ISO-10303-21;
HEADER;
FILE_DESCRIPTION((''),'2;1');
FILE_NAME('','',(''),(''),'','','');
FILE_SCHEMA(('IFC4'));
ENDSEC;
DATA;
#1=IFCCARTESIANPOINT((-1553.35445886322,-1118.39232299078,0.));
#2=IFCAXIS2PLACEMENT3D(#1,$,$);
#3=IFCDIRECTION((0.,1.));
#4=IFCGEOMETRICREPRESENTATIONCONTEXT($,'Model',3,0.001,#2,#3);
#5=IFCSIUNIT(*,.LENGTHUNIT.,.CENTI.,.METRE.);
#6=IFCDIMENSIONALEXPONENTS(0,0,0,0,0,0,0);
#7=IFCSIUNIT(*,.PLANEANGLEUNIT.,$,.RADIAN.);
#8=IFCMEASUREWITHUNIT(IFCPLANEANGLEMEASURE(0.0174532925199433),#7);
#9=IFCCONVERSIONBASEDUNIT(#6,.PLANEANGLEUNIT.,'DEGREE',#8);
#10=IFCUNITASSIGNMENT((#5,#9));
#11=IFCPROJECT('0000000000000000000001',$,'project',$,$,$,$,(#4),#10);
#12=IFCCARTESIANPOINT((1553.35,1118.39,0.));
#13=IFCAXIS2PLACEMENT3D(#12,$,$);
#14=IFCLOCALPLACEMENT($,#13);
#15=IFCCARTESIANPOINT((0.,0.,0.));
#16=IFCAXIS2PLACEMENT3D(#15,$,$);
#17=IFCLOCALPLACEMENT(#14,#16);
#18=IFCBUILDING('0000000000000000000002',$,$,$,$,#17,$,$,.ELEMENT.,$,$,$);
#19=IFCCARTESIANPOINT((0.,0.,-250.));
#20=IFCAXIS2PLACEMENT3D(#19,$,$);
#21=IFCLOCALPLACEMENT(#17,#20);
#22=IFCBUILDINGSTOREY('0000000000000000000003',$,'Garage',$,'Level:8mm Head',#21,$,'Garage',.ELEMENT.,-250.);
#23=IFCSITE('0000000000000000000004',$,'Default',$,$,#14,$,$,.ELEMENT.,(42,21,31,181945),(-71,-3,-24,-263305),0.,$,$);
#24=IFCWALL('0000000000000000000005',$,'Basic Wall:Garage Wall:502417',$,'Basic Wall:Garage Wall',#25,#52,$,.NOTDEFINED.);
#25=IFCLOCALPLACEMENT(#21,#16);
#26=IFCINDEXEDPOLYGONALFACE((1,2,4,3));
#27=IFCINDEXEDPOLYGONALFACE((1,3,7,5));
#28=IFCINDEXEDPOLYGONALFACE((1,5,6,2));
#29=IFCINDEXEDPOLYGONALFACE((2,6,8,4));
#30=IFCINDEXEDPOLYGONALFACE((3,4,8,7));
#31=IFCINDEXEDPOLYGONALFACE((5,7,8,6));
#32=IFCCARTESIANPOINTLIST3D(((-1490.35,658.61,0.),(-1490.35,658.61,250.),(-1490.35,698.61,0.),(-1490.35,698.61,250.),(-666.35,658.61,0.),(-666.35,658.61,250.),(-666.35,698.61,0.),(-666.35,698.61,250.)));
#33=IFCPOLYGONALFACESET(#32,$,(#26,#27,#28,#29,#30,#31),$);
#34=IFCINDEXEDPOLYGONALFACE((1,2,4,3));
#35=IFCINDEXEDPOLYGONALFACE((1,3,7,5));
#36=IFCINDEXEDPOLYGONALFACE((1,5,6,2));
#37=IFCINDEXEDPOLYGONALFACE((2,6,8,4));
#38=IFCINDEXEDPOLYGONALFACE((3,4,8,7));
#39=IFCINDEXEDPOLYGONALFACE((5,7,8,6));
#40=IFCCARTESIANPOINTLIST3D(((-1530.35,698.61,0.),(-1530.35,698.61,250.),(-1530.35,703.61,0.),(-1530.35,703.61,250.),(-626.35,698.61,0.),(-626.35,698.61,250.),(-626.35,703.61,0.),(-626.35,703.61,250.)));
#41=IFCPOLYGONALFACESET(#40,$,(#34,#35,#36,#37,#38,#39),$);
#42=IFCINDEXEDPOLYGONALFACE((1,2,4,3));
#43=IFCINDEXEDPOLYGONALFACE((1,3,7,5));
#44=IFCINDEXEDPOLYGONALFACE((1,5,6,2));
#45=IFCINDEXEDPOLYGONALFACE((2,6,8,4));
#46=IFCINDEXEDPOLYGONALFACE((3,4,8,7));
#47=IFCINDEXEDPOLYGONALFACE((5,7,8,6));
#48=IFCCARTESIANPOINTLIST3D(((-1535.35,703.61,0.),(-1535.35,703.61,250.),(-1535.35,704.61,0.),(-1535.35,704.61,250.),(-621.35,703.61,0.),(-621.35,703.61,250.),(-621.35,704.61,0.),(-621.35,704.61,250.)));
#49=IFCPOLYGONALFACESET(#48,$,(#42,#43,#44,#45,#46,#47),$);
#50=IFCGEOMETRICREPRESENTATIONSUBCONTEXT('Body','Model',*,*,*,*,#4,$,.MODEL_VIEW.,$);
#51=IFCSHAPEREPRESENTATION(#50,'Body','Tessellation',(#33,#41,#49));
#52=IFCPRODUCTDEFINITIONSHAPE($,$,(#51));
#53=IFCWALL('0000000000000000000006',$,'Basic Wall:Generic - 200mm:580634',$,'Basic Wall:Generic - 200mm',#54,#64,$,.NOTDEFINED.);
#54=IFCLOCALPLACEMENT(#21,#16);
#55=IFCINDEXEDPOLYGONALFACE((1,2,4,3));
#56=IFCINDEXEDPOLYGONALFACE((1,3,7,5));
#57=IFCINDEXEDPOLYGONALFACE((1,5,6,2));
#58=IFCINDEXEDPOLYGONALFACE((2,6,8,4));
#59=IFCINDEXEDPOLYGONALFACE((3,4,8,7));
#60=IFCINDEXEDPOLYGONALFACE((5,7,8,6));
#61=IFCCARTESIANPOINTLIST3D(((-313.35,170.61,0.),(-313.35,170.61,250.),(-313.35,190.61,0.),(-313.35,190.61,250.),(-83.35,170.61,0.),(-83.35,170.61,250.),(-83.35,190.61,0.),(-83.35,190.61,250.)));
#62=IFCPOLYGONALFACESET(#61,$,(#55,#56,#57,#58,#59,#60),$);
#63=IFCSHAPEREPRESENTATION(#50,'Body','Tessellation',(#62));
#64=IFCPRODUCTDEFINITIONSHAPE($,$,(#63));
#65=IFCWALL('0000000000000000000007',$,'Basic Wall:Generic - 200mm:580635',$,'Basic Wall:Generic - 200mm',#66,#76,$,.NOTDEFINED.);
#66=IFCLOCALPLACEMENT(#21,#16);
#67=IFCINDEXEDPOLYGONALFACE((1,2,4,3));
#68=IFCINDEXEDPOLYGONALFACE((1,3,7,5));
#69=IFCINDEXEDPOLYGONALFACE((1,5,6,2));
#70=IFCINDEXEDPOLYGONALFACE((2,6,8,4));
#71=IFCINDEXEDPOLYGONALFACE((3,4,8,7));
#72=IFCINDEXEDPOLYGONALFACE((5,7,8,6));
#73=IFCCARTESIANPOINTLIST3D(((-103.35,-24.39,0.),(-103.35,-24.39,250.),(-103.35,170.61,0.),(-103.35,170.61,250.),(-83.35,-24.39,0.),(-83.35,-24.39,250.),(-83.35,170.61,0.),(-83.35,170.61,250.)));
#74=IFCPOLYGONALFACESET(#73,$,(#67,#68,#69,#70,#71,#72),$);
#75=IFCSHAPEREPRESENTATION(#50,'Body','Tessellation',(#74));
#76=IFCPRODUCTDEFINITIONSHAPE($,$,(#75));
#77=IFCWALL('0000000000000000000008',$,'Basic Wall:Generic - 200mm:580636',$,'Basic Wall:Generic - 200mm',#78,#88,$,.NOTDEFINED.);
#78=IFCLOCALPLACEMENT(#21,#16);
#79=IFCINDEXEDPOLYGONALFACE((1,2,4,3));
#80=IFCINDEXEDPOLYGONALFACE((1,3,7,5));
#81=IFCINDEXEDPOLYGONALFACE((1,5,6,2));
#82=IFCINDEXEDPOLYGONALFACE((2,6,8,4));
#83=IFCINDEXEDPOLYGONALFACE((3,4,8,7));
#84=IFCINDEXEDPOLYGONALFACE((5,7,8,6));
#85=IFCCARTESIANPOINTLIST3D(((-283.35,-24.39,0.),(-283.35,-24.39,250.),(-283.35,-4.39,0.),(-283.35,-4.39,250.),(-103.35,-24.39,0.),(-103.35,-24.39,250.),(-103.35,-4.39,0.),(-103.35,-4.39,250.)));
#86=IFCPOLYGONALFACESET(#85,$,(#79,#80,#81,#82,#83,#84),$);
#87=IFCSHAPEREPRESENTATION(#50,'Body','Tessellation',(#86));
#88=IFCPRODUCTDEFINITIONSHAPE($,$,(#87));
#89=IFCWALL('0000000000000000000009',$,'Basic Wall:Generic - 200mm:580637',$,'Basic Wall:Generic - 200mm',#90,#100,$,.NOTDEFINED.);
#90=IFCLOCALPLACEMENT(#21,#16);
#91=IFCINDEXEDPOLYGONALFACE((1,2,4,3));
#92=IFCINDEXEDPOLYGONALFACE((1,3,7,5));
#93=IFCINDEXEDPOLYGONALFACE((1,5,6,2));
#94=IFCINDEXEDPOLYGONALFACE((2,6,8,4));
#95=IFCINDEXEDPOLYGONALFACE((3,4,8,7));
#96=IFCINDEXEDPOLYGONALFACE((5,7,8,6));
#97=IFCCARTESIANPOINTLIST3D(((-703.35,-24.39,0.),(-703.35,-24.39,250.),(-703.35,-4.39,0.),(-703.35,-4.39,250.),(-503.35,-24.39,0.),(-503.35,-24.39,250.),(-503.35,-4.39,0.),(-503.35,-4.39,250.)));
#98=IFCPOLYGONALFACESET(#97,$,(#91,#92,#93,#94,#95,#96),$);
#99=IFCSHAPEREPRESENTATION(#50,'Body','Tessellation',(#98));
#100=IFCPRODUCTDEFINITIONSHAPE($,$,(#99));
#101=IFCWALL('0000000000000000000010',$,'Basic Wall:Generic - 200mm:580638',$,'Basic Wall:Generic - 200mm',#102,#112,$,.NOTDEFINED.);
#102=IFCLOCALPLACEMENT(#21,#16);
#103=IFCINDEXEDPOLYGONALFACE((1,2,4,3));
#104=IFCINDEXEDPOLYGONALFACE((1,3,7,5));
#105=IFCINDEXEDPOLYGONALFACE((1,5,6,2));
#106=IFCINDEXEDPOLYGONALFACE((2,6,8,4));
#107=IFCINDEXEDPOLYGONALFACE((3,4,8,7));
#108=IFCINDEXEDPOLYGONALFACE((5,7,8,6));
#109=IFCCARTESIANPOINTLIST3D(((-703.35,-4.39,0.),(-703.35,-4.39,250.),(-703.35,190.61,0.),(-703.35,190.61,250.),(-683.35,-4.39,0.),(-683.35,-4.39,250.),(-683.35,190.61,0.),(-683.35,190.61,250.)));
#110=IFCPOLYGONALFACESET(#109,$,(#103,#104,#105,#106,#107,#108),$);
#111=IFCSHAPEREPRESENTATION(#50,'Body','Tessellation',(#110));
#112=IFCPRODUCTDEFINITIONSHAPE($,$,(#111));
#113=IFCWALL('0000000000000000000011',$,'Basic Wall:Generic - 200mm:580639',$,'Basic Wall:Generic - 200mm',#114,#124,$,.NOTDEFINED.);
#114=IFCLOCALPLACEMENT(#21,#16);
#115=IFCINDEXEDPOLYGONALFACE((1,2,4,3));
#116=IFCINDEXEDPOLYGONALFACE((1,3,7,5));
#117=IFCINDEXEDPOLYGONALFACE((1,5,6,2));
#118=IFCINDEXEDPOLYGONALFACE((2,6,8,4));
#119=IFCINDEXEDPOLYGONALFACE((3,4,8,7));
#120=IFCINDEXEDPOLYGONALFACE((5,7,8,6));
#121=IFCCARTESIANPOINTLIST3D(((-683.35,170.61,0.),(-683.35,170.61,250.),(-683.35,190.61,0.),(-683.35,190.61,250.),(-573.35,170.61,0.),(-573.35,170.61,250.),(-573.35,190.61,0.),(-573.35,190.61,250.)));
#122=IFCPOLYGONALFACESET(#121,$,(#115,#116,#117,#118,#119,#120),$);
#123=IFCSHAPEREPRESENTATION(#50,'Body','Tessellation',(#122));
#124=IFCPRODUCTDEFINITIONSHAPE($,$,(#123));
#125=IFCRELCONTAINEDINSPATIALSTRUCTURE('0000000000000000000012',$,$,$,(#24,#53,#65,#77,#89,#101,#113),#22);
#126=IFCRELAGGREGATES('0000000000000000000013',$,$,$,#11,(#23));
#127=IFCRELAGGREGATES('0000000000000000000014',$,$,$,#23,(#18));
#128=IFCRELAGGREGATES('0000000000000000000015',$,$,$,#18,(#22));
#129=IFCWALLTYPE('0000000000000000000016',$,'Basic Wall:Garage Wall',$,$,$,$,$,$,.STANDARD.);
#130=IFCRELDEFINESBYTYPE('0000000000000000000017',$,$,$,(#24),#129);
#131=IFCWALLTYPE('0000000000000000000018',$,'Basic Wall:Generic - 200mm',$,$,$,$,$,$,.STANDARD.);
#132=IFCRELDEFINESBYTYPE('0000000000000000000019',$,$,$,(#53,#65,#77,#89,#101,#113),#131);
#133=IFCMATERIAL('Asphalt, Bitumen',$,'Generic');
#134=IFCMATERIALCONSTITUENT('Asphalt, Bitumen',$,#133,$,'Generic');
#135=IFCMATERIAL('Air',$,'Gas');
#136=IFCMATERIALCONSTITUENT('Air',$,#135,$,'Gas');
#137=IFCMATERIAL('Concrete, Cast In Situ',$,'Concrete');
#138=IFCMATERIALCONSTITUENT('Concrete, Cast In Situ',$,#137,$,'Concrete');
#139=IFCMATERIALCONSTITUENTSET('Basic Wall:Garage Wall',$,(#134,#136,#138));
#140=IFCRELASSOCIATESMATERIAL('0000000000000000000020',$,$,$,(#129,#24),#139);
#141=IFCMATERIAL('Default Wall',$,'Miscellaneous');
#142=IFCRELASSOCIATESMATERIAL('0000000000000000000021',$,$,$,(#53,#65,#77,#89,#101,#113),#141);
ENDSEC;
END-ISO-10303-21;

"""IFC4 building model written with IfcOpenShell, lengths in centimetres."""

from ifc_helpers import new_model, entity, si_unit, converted_unit, direction, frame, origin, place, context, subcontext, project, spatial, indexed_curve, outline, extrude, material, constituent, constituent_set, type_object, element, save


model = new_model("IFC4")

# Units and contexts
model_context = context("Model", 3, precision=0.001, world=frame((-1553.35445886322, -1118.39232299078, 0.0)), true_north=direction((0.0, 1.0)))
body_context = subcontext(model_context, "Body", "Model", "MODEL_VIEW")
ifc_project = project(units=[si_unit("LENGTHUNIT", "METRE", prefix="CENTI"), converted_unit("PLANEANGLEUNIT", "DEGREE", entity("IfcPlaneAngleMeasure", 0.0174532925199433), si_unit("PLANEANGLEUNIT", "RADIAN"), dimensions=[0, 0, 0, 0, 0, 0, 0])], contexts=[model_context])

# Site, building, storey
site_placement = place(None, frame((1553.35, 1118.39, 0.0)))
site = spatial("IfcSite", under=ifc_project, at=site_placement, Name="Default", CompositionType="ELEMENT", RefLatitude=(42, 21, 31, 181945), RefLongitude=(-71, -3, -24, -263305), RefElevation=0.0)
building_placement = place(site_placement, origin())
building = spatial("IfcBuilding", under=site, at=building_placement, CompositionType="ELEMENT")
storey_placement = place(building_placement, frame((0.0, 0.0, -250.0)))
storey = spatial("IfcBuildingStorey", under=building, at=storey_placement, Name="Garage", ObjectType="Level:8mm Head", LongName="Garage", CompositionType="ELEMENT", Elevation=-250.0)

# Walls
ifc_material_1 = material(Name="Concrete, Cast In Situ", Category="Concrete")
ifc_material_2 = material(Name="Asphalt, Bitumen", Category="Generic")
ifc_constituent_1 = constituent(ifc_material_2, Name="Asphalt, Bitumen", Category="Generic")
ifc_material_3 = material(Name="Air", Category="Gas")
ifc_constituent_2 = constituent(ifc_material_3, Name="Air", Category="Gas")
ifc_constituent_3 = constituent(ifc_material_1, Name="Concrete, Cast In Situ", Category="Concrete")
ifc_constituent_set = constituent_set(constituents=[ifc_constituent_1, ifc_constituent_2, ifc_constituent_3], Name="Basic Wall:Garage Wall")
wall_type_1 = type_object("IfcWallType", Name="Basic Wall:Garage Wall", PredefinedType="STANDARD", material=ifc_constituent_set)
wall_1_placement = place(storey_placement, frame((-1490.35, 681.61, 0.0)))
element("IfcWall", 1, at=wall_1_placement, inside=storey, type_object=wall_type_1, material=ifc_constituent_set, Name="Basic Wall:Garage Wall:502417", ObjectType="Basic Wall:Garage Wall", PredefinedType="NOTDEFINED", context=body_context, shape_type="SweptSolid", body=[
    extrude(outline(indexed_curve([(-20.0, -412.0), (20.0, -412.0), (20.0, 412.0), (-20.0, 412.0), (-20.0, -412.0)], self_intersect=False)), frame((412.0, -3.0, 0.0), z_axis=(0.0, 0.0, 1.0), x_axis=(0.0, 1.0, 0.0)), (0.0, 0.0, 1.0), 250.0),
    extrude(outline(indexed_curve([(-452.0, -2.5), (452.0, -2.5), (452.0, 2.5), (-452.0, 2.5), (-452.0, -2.5)], self_intersect=False)), frame((412.0, 19.5, 0.0)), (0.0, 0.0, 1.0), 250.0),
    extrude(outline(indexed_curve([(-0.5, -457.0), (0.5, -457.0), (0.5, 457.0), (-0.5, 457.0), (-0.5, -457.0)], self_intersect=False)), frame((412.0, 22.5, 0.0), z_axis=(0.0, 0.0, 1.0), x_axis=(0.0, -1.0, 0.0)), (0.0, 0.0, 1.0), 250.0),
])
ifc_material_4 = material(Name="Default Wall", Category="Miscellaneous")
wall_type_2 = type_object("IfcWallType", Name="Basic Wall:Generic - 200mm", PredefinedType="STANDARD")
wall_2_placement = place(storey_placement, frame((-313.35, 180.61, 0.0)))
element("IfcWall", 2, at=wall_2_placement, inside=storey, type_object=wall_type_2, material=ifc_material_4, Name="Basic Wall:Generic - 200mm:580634", ObjectType="Basic Wall:Generic - 200mm", PredefinedType="NOTDEFINED", context=body_context, shape_type="SweptSolid", body=[
    extrude(outline(indexed_curve([(230.0, 10.0), (0.0, 10.0), (0.0, -10.0), (230.0, -10.0), (230.0, 10.0)], self_intersect=False)), origin(), (0.0, 0.0, 1.0), 250.0),
])
wall_3_placement = place(storey_placement, frame((-93.35, 170.61, 0.0), z_axis=(0.0, 0.0, 1.0), x_axis=(0.0, -1.0, 0.0)))
element("IfcWall", 3, at=wall_3_placement, inside=storey, type_object=wall_type_2, material=ifc_material_4, Name="Basic Wall:Generic - 200mm:580635", ObjectType="Basic Wall:Generic - 200mm", PredefinedType="NOTDEFINED", context=body_context, shape_type="SweptSolid", body=[
    extrude(outline(indexed_curve([(195.0, 10.0), (0.0, 10.0), (0.0, -10.0), (195.0, -10.0), (195.0, 10.0)], self_intersect=False)), origin(), (0.0, 0.0, 1.0), 250.0),
])
wall_4_placement = place(storey_placement, frame((-283.35, -14.39, 0.0)))
element("IfcWall", 4, at=wall_4_placement, inside=storey, type_object=wall_type_2, material=ifc_material_4, Name="Basic Wall:Generic - 200mm:580636", ObjectType="Basic Wall:Generic - 200mm", PredefinedType="NOTDEFINED", context=body_context, shape_type="SweptSolid", body=[
    extrude(outline(indexed_curve([(180.0, 10.0), (0.0, 10.0), (0.0, -10.0), (180.0, -10.0), (180.0, 10.0)], self_intersect=False)), origin(), (0.0, 0.0, 1.0), 250.0),
])
wall_5_placement = place(storey_placement, frame((-503.35, -14.39, 0.0), z_axis=(0.0, 0.0, 1.0), x_axis=(-1.0, 0.0, 0.0)))
element("IfcWall", 5, at=wall_5_placement, inside=storey, type_object=wall_type_2, material=ifc_material_4, Name="Basic Wall:Generic - 200mm:580637", ObjectType="Basic Wall:Generic - 200mm", PredefinedType="NOTDEFINED", context=body_context, shape_type="SweptSolid", body=[
    extrude(outline(indexed_curve([(200.0, 10.0), (0.0, 10.0), (0.0, -10.0), (200.0, -10.0), (200.0, 10.0)], self_intersect=False)), origin(), (0.0, 0.0, 1.0), 250.0),
])
wall_6_placement = place(storey_placement, frame((-693.35, -4.39, 0.0), z_axis=(0.0, 0.0, 1.0), x_axis=(0.0, 1.0, 0.0)))
element("IfcWall", 6, at=wall_6_placement, inside=storey, type_object=wall_type_2, material=ifc_material_4, Name="Basic Wall:Generic - 200mm:580638", ObjectType="Basic Wall:Generic - 200mm", PredefinedType="NOTDEFINED", context=body_context, shape_type="SweptSolid", body=[
    extrude(outline(indexed_curve([(195.0, 10.0), (0.0, 10.0), (0.0, -10.0), (195.0, -10.0), (195.0, 10.0)], self_intersect=False)), origin(), (0.0, 0.0, 1.0), 250.0),
])
wall_7_placement = place(storey_placement, frame((-683.35, 180.61, 0.0)))
element("IfcWall", 7, at=wall_7_placement, inside=storey, type_object=wall_type_2, material=ifc_material_4, Name="Basic Wall:Generic - 200mm:580639", ObjectType="Basic Wall:Generic - 200mm", PredefinedType="NOTDEFINED", context=body_context, shape_type="SweptSolid", body=[
    extrude(outline(indexed_curve([(110.0, 10.0), (0.0, 10.0), (0.0, -10.0), (110.0, -10.0), (110.0, 10.0)], self_intersect=False)), origin(), (0.0, 0.0, 1.0), 250.0),
])

save(model, "model.ifc")
